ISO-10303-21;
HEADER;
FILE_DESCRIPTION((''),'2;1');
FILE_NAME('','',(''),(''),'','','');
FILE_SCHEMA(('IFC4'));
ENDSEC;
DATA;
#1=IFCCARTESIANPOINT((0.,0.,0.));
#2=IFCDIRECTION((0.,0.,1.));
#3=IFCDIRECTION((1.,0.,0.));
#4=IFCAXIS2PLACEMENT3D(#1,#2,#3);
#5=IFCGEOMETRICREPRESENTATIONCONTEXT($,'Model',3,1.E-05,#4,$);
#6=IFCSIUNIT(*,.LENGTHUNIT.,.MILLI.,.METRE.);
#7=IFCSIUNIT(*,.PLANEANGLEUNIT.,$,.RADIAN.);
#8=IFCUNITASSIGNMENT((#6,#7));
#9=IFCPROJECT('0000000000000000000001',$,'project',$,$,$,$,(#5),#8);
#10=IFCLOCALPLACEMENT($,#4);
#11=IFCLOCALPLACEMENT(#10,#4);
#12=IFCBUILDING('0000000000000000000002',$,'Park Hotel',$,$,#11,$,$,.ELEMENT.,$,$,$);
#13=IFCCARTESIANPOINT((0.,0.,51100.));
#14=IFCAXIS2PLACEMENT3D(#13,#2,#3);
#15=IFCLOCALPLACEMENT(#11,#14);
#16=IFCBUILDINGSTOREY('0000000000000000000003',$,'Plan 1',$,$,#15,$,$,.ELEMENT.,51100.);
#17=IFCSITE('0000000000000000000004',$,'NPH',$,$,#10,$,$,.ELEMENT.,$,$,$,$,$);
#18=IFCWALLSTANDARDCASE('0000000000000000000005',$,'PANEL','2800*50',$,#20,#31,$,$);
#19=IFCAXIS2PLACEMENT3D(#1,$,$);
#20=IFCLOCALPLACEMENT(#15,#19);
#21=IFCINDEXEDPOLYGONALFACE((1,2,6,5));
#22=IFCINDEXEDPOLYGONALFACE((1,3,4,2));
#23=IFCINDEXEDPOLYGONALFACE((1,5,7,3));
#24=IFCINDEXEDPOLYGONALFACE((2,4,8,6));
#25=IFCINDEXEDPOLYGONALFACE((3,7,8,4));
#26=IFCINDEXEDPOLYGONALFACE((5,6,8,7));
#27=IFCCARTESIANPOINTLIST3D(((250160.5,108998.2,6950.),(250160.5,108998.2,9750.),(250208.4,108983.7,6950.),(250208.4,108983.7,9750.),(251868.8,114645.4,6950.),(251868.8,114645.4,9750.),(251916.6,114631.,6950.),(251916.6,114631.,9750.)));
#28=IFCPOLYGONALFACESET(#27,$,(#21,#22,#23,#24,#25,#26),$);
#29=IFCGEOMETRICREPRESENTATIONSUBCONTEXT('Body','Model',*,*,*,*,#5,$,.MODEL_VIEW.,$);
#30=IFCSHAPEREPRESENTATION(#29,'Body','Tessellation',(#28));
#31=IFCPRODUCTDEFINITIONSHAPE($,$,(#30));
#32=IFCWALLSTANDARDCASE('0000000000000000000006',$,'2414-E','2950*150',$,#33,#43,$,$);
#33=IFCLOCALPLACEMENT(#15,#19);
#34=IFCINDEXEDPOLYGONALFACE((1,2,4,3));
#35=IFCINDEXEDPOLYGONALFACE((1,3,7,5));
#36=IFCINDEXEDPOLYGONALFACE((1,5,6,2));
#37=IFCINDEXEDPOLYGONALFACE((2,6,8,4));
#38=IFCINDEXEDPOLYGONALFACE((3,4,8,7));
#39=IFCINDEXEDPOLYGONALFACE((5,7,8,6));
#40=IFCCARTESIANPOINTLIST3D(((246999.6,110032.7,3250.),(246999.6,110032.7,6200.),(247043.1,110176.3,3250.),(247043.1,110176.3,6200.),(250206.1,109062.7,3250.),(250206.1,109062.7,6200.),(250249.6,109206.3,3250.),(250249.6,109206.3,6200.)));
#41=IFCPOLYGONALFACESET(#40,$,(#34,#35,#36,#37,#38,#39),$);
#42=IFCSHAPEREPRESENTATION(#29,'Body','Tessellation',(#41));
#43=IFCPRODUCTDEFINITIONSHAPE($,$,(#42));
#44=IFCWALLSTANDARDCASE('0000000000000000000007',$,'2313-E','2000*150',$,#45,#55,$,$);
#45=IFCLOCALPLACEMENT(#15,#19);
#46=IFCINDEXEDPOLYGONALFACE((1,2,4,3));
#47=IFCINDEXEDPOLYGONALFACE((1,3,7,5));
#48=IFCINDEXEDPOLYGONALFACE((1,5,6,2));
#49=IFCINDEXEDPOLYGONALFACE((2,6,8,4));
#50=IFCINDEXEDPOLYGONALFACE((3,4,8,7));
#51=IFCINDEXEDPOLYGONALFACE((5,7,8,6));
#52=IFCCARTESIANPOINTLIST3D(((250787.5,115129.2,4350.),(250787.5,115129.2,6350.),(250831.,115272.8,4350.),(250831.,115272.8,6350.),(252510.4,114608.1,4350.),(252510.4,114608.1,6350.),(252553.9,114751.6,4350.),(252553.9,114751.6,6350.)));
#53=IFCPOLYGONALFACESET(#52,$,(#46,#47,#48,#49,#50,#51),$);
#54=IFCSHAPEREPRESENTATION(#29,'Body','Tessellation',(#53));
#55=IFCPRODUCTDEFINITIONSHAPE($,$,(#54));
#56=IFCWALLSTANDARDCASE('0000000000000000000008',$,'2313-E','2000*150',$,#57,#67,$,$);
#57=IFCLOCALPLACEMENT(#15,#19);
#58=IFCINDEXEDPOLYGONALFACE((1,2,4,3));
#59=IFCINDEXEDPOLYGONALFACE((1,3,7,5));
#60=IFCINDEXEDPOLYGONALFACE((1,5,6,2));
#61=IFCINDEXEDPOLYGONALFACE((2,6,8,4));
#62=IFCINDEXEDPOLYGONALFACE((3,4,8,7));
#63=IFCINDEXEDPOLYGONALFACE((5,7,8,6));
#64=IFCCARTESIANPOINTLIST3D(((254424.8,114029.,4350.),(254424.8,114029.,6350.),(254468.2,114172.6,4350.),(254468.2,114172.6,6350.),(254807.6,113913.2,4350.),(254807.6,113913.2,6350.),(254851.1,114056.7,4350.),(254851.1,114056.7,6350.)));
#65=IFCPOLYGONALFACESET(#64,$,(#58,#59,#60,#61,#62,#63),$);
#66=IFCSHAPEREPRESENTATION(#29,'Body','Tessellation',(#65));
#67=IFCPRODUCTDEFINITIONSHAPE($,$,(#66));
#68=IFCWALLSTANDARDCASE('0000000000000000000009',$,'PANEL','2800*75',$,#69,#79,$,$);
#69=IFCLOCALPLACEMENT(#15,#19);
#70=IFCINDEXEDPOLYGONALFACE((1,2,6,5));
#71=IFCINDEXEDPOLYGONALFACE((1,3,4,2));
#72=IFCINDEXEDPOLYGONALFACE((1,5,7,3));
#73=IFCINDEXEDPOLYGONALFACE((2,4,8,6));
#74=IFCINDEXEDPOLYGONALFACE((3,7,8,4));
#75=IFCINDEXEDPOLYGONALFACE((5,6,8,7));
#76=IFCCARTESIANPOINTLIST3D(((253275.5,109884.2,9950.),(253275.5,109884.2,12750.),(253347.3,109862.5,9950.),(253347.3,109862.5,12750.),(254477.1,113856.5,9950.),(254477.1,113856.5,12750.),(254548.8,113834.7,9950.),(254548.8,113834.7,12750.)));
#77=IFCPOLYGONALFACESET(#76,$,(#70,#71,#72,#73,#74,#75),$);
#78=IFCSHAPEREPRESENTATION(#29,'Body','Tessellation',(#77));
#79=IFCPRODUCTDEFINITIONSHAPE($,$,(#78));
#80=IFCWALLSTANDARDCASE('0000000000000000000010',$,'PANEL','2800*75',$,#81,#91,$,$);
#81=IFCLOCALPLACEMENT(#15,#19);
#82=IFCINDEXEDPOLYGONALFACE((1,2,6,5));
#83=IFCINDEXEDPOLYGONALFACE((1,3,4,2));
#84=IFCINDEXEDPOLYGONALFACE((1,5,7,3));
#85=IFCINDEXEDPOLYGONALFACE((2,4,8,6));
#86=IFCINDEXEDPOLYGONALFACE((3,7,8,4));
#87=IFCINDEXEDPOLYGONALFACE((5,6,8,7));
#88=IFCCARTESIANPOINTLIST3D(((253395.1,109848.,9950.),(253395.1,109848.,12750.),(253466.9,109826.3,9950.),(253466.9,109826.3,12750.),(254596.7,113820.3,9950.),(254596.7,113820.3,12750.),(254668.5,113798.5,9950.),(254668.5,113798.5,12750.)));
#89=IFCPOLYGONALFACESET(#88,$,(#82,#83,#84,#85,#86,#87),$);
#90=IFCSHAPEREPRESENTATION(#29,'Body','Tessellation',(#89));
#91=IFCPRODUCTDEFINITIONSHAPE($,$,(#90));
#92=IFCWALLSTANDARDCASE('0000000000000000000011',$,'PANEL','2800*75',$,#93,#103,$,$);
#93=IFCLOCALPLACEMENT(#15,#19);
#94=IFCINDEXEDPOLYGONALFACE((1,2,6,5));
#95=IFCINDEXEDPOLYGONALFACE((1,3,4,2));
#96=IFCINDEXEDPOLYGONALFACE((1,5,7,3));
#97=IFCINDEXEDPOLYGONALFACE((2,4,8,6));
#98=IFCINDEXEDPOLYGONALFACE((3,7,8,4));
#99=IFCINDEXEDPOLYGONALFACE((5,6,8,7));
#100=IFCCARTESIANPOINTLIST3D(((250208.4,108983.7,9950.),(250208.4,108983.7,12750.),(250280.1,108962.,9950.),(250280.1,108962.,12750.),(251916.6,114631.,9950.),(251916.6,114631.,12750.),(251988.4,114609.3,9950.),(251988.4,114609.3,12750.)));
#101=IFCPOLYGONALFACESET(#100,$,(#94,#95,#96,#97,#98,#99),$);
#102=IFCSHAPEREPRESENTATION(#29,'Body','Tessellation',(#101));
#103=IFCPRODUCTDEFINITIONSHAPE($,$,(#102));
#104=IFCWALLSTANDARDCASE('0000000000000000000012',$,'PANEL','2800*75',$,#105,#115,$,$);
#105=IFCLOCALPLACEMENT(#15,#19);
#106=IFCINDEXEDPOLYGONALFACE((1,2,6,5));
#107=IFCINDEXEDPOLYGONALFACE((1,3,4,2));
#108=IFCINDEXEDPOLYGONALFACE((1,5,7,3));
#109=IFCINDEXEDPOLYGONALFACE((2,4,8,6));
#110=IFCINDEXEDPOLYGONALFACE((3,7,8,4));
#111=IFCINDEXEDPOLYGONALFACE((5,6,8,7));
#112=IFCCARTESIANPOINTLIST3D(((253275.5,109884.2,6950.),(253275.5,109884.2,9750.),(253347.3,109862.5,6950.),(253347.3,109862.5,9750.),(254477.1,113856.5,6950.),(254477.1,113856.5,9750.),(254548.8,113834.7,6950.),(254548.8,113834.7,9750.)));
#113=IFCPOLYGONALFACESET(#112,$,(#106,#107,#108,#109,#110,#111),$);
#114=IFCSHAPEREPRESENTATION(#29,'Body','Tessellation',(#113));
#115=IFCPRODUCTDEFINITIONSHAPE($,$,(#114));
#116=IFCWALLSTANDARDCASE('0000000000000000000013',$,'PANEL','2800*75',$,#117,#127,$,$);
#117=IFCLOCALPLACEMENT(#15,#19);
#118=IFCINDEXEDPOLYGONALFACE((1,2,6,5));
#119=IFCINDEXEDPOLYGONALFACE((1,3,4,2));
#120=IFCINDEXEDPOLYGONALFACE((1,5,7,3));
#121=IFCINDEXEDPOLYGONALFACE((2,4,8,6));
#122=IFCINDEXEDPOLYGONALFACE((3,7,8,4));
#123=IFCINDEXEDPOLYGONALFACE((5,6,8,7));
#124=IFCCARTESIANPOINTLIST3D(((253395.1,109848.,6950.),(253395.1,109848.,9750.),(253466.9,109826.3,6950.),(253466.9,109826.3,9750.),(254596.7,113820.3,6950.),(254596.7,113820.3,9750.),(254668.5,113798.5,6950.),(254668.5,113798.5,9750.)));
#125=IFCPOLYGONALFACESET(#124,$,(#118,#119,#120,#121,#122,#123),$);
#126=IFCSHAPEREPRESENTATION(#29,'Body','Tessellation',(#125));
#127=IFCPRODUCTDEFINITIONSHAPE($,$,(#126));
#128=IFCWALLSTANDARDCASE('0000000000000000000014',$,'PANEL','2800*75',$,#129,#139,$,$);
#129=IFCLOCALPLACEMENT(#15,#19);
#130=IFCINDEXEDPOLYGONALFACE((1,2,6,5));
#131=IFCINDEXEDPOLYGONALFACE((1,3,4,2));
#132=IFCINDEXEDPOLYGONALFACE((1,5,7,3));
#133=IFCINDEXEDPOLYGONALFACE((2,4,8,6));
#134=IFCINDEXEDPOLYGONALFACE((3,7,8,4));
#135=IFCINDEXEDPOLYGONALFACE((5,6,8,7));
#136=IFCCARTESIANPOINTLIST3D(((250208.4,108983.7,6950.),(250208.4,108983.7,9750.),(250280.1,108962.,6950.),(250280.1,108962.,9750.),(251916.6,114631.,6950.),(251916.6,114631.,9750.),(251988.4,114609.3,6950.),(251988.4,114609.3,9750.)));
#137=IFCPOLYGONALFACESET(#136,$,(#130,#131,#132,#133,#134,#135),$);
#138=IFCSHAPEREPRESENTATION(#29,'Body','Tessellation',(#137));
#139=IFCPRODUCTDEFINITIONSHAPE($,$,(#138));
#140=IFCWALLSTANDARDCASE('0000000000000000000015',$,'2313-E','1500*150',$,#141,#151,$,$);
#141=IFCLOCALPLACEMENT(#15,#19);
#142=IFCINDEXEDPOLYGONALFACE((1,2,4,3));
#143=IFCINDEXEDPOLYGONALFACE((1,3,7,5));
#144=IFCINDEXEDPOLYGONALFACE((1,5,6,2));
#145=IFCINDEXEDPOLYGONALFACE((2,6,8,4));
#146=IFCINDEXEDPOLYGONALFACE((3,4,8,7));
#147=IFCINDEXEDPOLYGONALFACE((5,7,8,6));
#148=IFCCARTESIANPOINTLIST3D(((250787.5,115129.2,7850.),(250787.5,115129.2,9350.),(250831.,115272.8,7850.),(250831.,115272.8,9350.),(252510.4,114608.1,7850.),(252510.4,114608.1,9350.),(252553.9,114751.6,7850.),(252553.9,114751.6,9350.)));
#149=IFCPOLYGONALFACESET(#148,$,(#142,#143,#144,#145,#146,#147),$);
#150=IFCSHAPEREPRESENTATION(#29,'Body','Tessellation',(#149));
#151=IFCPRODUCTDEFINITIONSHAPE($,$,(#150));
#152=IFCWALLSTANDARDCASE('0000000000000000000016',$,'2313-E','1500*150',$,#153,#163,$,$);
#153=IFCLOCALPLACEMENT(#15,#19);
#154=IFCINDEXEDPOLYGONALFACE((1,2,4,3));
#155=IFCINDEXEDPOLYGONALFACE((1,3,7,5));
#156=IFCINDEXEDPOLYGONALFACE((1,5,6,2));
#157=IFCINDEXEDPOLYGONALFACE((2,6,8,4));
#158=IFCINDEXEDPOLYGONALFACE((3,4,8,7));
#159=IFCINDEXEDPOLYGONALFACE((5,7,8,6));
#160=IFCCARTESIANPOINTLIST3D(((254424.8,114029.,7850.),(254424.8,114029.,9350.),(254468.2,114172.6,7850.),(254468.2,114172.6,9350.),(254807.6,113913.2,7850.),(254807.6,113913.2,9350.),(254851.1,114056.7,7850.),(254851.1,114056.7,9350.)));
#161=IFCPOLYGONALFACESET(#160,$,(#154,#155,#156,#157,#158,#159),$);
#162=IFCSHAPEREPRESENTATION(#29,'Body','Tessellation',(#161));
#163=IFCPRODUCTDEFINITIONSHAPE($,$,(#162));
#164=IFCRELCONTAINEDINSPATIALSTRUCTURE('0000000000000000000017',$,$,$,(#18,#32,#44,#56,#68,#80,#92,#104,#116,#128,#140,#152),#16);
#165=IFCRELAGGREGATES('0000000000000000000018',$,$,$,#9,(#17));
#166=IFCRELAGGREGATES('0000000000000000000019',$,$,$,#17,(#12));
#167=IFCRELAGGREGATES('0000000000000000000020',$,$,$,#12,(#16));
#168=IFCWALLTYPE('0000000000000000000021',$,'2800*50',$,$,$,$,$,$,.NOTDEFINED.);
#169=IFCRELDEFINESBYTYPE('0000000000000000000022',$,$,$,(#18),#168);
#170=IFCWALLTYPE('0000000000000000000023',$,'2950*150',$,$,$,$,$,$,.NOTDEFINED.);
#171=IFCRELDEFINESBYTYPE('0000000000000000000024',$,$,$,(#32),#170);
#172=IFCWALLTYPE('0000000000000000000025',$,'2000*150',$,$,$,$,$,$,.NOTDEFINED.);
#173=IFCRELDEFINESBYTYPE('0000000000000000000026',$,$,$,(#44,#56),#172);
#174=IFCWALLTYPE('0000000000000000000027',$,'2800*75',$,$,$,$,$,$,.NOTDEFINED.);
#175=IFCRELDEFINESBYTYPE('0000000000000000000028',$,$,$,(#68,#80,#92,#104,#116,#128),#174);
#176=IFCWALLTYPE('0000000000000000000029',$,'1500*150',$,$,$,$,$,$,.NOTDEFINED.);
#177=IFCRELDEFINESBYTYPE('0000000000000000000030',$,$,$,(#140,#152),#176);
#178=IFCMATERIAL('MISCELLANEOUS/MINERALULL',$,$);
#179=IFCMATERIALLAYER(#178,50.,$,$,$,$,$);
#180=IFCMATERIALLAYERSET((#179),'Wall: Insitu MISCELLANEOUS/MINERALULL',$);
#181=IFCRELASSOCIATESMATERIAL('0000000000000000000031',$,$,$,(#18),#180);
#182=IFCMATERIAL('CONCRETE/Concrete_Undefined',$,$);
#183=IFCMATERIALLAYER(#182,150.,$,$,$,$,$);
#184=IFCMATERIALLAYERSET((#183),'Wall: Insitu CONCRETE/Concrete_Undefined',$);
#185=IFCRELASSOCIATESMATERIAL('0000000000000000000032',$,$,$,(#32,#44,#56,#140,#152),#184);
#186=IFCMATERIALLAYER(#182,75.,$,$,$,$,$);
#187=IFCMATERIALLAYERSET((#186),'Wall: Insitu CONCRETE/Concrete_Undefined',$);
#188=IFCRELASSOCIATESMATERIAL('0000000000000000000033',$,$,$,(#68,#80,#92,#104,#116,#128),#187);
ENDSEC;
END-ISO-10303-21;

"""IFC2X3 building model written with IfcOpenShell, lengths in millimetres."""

from ifc_helpers import new_model, si_unit, frame, frame_2d, origin_with_axes, place, context, subcontext, project, spatial, rectangle, extrude, material, layer, layer_set, layer_usage, type_object, element, save


model = new_model("IFC2X3")

# Units and contexts
model_context = context("Model", 3, precision=1e-05, world=origin_with_axes())
body_context = subcontext(model_context, "Body", "Model", "MODEL_VIEW")
ifc_project = project(units=[si_unit("LENGTHUNIT", "METRE", prefix="MILLI"), si_unit("PLANEANGLEUNIT", "RADIAN")], contexts=[model_context])

# Site, building, storey
site_placement = place(None, origin_with_axes())
site = spatial("IfcSite", under=ifc_project, at=site_placement, Name="NPH", CompositionType="ELEMENT")
building_placement = place(site_placement, origin_with_axes())
building = spatial("IfcBuilding", under=site, at=building_placement, Name="Park Hotel", CompositionType="ELEMENT")
storey_placement = place(building_placement, frame((0.0, 0.0, 51100.0), z_axis=(0.0, 0.0, 1.0), x_axis=(1.0, 0.0, 0.0)))
storey = spatial("IfcBuildingStorey", under=building, at=storey_placement, Name="Plan 1", CompositionType="ELEMENT", Elevation=51100.0)

# Shared definitions
ifc_material_1 = material(Name="CONCRETE/Concrete_Undefined")

# Walls
ifc_layer_1 = layer(ifc_material_1, 150.0)
ifc_layer_set_1 = layer_set([ifc_layer_1], Name="Wall: Insitu CONCRETE/Concrete_Undefined")
ifc_material_2 = material(Name="MISCELLANEOUS/MINERALULL")
ifc_layer_2 = layer(ifc_material_2, 50.0)
ifc_layer_set_2 = layer_set([ifc_layer_2], Name="Wall: Insitu MISCELLANEOUS/MINERALULL")
wall_type_1 = type_object("IfcWallType", Name="2800*50", PredefinedType="NOTDEFINED")
ifc_layer_usage_1 = layer_usage(ifc_layer_set_2, "AXIS2", "POSITIVE", -25.0)
wall_1_placement = place(storey_placement, frame((250184.4, 108990.9, 6950.0), z_axis=(0.0, 0.0, 1.0), x_axis=(0.289539, 0.957166, 0.0)))
element("IfcWallStandardCase", 1, at=wall_1_placement, inside=storey, type_object=wall_type_1, material=ifc_layer_usage_1, Name="PANEL", Description="2800*50", context=body_context, shape_type="SweptSolid", body=[
    extrude(rectangle(XDim=5900.0, YDim=50.0, at=frame_2d((0.0, 2950.0), x_axis=(0.0, -1.0))), frame((0.0, 0.0, 0.0), z_axis=(0.0, 0.0, 1.0), x_axis=(0.0, -1.0, 0.0)), (0.0, 0.0, 1.0), 2800.0),
])
ifc_layer_usage_2 = layer_usage(ifc_layer_set_1, "AXIS2", "POSITIVE", -75.0)
wall_type_2 = type_object("IfcWallType", Name="2950*150", PredefinedType="NOTDEFINED")
wall_2_placement = place(storey_placement, frame((250227.9, 109134.5, 3250.0), z_axis=(0.0, 0.0, 1.0), x_axis=(-0.957166, 0.289539, 0.0)))
element("IfcWallStandardCase", 2, at=wall_2_placement, inside=storey, type_object=wall_type_2, material=ifc_layer_usage_2, Name="2414-E", Description="2950*150", context=body_context, shape_type="SweptSolid", body=[
    extrude(rectangle(XDim=3350.0, YDim=150.0, at=frame_2d((0.0, 1675.0), x_axis=(0.0, -1.0))), frame((0.0, 0.0, 0.0), z_axis=(0.0, 0.0, 1.0), x_axis=(0.0, -1.0, 0.0)), (0.0, 0.0, 1.0), 2950.0),
])
ifc_layer_usage_3 = layer_usage(ifc_layer_set_1, "AXIS2", "POSITIVE", -75.0)
wall_type_3 = type_object("IfcWallType", Name="2000*150", PredefinedType="NOTDEFINED")
wall_3_placement = place(storey_placement, frame((250809.3, 115201.0, 4350.0), z_axis=(0.0, 0.0, 1.0), x_axis=(0.957166, -0.289541, 0.0)))
element("IfcWallStandardCase", 3, at=wall_3_placement, inside=storey, type_object=wall_type_3, material=ifc_layer_usage_3, Name="2313-E", Description="2000*150", context=body_context, shape_type="SweptSolid", body=[
    extrude(rectangle(XDim=1800.0, YDim=150.0, at=frame_2d((0.0, 900.0), x_axis=(0.0, -1.0))), frame((0.0, 0.0, 0.0), z_axis=(0.0, 0.0, 1.0), x_axis=(0.0, -1.0, 0.0)), (0.0, 0.0, 1.0), 2000.0),
])
ifc_layer_usage_4 = layer_usage(ifc_layer_set_1, "AXIS2", "POSITIVE", -75.0)
wall_4_placement = place(storey_placement, frame((254446.5, 114100.8, 4350.0), z_axis=(0.0, 0.0, 1.0), x_axis=(0.957161, -0.289556, 0.0)))
element("IfcWallStandardCase", 4, at=wall_4_placement, inside=storey, type_object=wall_type_3, material=ifc_layer_usage_4, Name="2313-E", Description="2000*150", context=body_context, shape_type="SweptSolid", body=[
    extrude(rectangle(XDim=400.0, YDim=150.0, at=frame_2d((0.0, 200.0), x_axis=(0.0, -1.0))), frame((0.0, 0.0, 0.0), z_axis=(0.0, 0.0, 1.0), x_axis=(0.0, -1.0, 0.0)), (0.0, 0.0, 1.0), 2000.0),
])
ifc_layer_3 = layer(ifc_material_1, 75.0)
ifc_layer_set_3 = layer_set([ifc_layer_3], Name="Wall: Insitu CONCRETE/Concrete_Undefined")
ifc_layer_usage_5 = layer_usage(ifc_layer_set_3, "AXIS2", "POSITIVE", -37.5)
wall_type_4 = type_object("IfcWallType", Name="2800*75", PredefinedType="NOTDEFINED")
wall_5_placement = place(storey_placement, frame((253311.4, 109873.4, 9950.0), z_axis=(0.0, 0.0, 1.0), x_axis=(0.289539, 0.957166, 0.0)))
element("IfcWallStandardCase", 5, at=wall_5_placement, inside=storey, type_object=wall_type_4, material=ifc_layer_usage_5, Name="PANEL", Description="2800*75", context=body_context, shape_type="SweptSolid", body=[
    extrude(rectangle(XDim=4150.0, YDim=75.0, at=frame_2d((0.0, 2075.0), x_axis=(0.0, -1.0))), frame((0.0, 0.0, 0.0), z_axis=(0.0, 0.0, 1.0), x_axis=(0.0, -1.0, 0.0)), (0.0, 0.0, 1.0), 2800.0),
])
ifc_layer_usage_6 = layer_usage(ifc_layer_set_3, "AXIS2", "POSITIVE", -37.5)
wall_6_placement = place(storey_placement, frame((253431.0, 109837.2, 9950.0), z_axis=(0.0, 0.0, 1.0), x_axis=(0.289539, 0.957166, 0.0)))
element("IfcWallStandardCase", 6, at=wall_6_placement, inside=storey, type_object=wall_type_4, material=ifc_layer_usage_6, Name="PANEL", Description="2800*75", context=body_context, shape_type="SweptSolid", body=[
    extrude(rectangle(XDim=4150.0, YDim=75.0, at=frame_2d((0.0, 2075.0), x_axis=(0.0, -1.0))), frame((0.0, 0.0, 0.0), z_axis=(0.0, 0.0, 1.0), x_axis=(0.0, -1.0, 0.0)), (0.0, 0.0, 1.0), 2800.0),
])
ifc_layer_usage_7 = layer_usage(ifc_layer_set_3, "AXIS2", "POSITIVE", -37.5)
wall_7_placement = place(storey_placement, frame((250244.2, 108972.8, 9950.0), z_axis=(0.0, 0.0, 1.0), x_axis=(0.289539, 0.957166, 0.0)))
element("IfcWallStandardCase", 7, at=wall_7_placement, inside=storey, type_object=wall_type_4, material=ifc_layer_usage_7, Name="PANEL", Description="2800*75", context=body_context, shape_type="SweptSolid", body=[
    extrude(rectangle(XDim=5900.0, YDim=75.0, at=frame_2d((0.0, 2950.0), x_axis=(0.0, -1.0))), frame((0.0, 0.0, 0.0), z_axis=(0.0, 0.0, 1.0), x_axis=(0.0, -1.0, 0.0)), (0.0, 0.0, 1.0), 2800.0),
])
ifc_layer_usage_8 = layer_usage(ifc_layer_set_3, "AXIS2", "POSITIVE", -37.5)
wall_8_placement = place(storey_placement, frame((253311.4, 109873.4, 6950.0), z_axis=(0.0, 0.0, 1.0), x_axis=(0.289539, 0.957166, 0.0)))
element("IfcWallStandardCase", 8, at=wall_8_placement, inside=storey, type_object=wall_type_4, material=ifc_layer_usage_8, Name="PANEL", Description="2800*75", context=body_context, shape_type="SweptSolid", body=[
    extrude(rectangle(XDim=4150.0, YDim=75.0, at=frame_2d((0.0, 2075.0), x_axis=(0.0, -1.0))), frame((0.0, 0.0, 0.0), z_axis=(0.0, 0.0, 1.0), x_axis=(0.0, -1.0, 0.0)), (0.0, 0.0, 1.0), 2800.0),
])
ifc_layer_usage_9 = layer_usage(ifc_layer_set_3, "AXIS2", "POSITIVE", -37.5)
wall_9_placement = place(storey_placement, frame((253431.0, 109837.2, 6950.0), z_axis=(0.0, 0.0, 1.0), x_axis=(0.289539, 0.957166, 0.0)))
element("IfcWallStandardCase", 9, at=wall_9_placement, inside=storey, type_object=wall_type_4, material=ifc_layer_usage_9, Name="PANEL", Description="2800*75", context=body_context, shape_type="SweptSolid", body=[
    extrude(rectangle(XDim=4150.0, YDim=75.0, at=frame_2d((0.0, 2075.0), x_axis=(0.0, -1.0))), frame((0.0, 0.0, 0.0), z_axis=(0.0, 0.0, 1.0), x_axis=(0.0, -1.0, 0.0)), (0.0, 0.0, 1.0), 2800.0),
])
ifc_layer_usage_10 = layer_usage(ifc_layer_set_3, "AXIS2", "POSITIVE", -37.5)
wall_10_placement = place(storey_placement, frame((250244.2, 108972.8, 6950.0), z_axis=(0.0, 0.0, 1.0), x_axis=(0.289539, 0.957166, 0.0)))
element("IfcWallStandardCase", 10, at=wall_10_placement, inside=storey, type_object=wall_type_4, material=ifc_layer_usage_10, Name="PANEL", Description="2800*75", context=body_context, shape_type="SweptSolid", body=[
    extrude(rectangle(XDim=5900.0, YDim=75.0, at=frame_2d((0.0, 2950.0), x_axis=(0.0, -1.0))), frame((0.0, 0.0, 0.0), z_axis=(0.0, 0.0, 1.0), x_axis=(0.0, -1.0, 0.0)), (0.0, 0.0, 1.0), 2800.0),
])
ifc_layer_usage_11 = layer_usage(ifc_layer_set_1, "AXIS2", "POSITIVE", -75.0)
wall_type_5 = type_object("IfcWallType", Name="1500*150", PredefinedType="NOTDEFINED")
wall_11_placement = place(storey_placement, frame((250809.3, 115201.0, 7850.0), z_axis=(0.0, 0.0, 1.0), x_axis=(0.957166, -0.289541, 0.0)))
element("IfcWallStandardCase", 11, at=wall_11_placement, inside=storey, type_object=wall_type_5, material=ifc_layer_usage_11, Name="2313-E", Description="1500*150", context=body_context, shape_type="SweptSolid", body=[
    extrude(rectangle(XDim=1800.0, YDim=150.0, at=frame_2d((0.0, 900.0), x_axis=(0.0, -1.0))), frame((0.0, 0.0, 0.0), z_axis=(0.0, 0.0, 1.0), x_axis=(0.0, -1.0, 0.0)), (0.0, 0.0, 1.0), 1500.0),
])
ifc_layer_usage_12 = layer_usage(ifc_layer_set_1, "AXIS2", "POSITIVE", -75.0)
wall_12_placement = place(storey_placement, frame((254446.5, 114100.8, 7850.0), z_axis=(0.0, 0.0, 1.0), x_axis=(0.957161, -0.289556, 0.0)))
element("IfcWallStandardCase", 12, at=wall_12_placement, inside=storey, type_object=wall_type_5, material=ifc_layer_usage_12, Name="2313-E", Description="1500*150", context=body_context, shape_type="SweptSolid", body=[
    extrude(rectangle(XDim=400.0, YDim=150.0, at=frame_2d((0.0, 200.0), x_axis=(0.0, -1.0))), frame((0.0, 0.0, 0.0), z_axis=(0.0, 0.0, 1.0), x_axis=(0.0, -1.0, 0.0)), (0.0, 0.0, 1.0), 1500.0),
])

save(model, "model.ifc")
